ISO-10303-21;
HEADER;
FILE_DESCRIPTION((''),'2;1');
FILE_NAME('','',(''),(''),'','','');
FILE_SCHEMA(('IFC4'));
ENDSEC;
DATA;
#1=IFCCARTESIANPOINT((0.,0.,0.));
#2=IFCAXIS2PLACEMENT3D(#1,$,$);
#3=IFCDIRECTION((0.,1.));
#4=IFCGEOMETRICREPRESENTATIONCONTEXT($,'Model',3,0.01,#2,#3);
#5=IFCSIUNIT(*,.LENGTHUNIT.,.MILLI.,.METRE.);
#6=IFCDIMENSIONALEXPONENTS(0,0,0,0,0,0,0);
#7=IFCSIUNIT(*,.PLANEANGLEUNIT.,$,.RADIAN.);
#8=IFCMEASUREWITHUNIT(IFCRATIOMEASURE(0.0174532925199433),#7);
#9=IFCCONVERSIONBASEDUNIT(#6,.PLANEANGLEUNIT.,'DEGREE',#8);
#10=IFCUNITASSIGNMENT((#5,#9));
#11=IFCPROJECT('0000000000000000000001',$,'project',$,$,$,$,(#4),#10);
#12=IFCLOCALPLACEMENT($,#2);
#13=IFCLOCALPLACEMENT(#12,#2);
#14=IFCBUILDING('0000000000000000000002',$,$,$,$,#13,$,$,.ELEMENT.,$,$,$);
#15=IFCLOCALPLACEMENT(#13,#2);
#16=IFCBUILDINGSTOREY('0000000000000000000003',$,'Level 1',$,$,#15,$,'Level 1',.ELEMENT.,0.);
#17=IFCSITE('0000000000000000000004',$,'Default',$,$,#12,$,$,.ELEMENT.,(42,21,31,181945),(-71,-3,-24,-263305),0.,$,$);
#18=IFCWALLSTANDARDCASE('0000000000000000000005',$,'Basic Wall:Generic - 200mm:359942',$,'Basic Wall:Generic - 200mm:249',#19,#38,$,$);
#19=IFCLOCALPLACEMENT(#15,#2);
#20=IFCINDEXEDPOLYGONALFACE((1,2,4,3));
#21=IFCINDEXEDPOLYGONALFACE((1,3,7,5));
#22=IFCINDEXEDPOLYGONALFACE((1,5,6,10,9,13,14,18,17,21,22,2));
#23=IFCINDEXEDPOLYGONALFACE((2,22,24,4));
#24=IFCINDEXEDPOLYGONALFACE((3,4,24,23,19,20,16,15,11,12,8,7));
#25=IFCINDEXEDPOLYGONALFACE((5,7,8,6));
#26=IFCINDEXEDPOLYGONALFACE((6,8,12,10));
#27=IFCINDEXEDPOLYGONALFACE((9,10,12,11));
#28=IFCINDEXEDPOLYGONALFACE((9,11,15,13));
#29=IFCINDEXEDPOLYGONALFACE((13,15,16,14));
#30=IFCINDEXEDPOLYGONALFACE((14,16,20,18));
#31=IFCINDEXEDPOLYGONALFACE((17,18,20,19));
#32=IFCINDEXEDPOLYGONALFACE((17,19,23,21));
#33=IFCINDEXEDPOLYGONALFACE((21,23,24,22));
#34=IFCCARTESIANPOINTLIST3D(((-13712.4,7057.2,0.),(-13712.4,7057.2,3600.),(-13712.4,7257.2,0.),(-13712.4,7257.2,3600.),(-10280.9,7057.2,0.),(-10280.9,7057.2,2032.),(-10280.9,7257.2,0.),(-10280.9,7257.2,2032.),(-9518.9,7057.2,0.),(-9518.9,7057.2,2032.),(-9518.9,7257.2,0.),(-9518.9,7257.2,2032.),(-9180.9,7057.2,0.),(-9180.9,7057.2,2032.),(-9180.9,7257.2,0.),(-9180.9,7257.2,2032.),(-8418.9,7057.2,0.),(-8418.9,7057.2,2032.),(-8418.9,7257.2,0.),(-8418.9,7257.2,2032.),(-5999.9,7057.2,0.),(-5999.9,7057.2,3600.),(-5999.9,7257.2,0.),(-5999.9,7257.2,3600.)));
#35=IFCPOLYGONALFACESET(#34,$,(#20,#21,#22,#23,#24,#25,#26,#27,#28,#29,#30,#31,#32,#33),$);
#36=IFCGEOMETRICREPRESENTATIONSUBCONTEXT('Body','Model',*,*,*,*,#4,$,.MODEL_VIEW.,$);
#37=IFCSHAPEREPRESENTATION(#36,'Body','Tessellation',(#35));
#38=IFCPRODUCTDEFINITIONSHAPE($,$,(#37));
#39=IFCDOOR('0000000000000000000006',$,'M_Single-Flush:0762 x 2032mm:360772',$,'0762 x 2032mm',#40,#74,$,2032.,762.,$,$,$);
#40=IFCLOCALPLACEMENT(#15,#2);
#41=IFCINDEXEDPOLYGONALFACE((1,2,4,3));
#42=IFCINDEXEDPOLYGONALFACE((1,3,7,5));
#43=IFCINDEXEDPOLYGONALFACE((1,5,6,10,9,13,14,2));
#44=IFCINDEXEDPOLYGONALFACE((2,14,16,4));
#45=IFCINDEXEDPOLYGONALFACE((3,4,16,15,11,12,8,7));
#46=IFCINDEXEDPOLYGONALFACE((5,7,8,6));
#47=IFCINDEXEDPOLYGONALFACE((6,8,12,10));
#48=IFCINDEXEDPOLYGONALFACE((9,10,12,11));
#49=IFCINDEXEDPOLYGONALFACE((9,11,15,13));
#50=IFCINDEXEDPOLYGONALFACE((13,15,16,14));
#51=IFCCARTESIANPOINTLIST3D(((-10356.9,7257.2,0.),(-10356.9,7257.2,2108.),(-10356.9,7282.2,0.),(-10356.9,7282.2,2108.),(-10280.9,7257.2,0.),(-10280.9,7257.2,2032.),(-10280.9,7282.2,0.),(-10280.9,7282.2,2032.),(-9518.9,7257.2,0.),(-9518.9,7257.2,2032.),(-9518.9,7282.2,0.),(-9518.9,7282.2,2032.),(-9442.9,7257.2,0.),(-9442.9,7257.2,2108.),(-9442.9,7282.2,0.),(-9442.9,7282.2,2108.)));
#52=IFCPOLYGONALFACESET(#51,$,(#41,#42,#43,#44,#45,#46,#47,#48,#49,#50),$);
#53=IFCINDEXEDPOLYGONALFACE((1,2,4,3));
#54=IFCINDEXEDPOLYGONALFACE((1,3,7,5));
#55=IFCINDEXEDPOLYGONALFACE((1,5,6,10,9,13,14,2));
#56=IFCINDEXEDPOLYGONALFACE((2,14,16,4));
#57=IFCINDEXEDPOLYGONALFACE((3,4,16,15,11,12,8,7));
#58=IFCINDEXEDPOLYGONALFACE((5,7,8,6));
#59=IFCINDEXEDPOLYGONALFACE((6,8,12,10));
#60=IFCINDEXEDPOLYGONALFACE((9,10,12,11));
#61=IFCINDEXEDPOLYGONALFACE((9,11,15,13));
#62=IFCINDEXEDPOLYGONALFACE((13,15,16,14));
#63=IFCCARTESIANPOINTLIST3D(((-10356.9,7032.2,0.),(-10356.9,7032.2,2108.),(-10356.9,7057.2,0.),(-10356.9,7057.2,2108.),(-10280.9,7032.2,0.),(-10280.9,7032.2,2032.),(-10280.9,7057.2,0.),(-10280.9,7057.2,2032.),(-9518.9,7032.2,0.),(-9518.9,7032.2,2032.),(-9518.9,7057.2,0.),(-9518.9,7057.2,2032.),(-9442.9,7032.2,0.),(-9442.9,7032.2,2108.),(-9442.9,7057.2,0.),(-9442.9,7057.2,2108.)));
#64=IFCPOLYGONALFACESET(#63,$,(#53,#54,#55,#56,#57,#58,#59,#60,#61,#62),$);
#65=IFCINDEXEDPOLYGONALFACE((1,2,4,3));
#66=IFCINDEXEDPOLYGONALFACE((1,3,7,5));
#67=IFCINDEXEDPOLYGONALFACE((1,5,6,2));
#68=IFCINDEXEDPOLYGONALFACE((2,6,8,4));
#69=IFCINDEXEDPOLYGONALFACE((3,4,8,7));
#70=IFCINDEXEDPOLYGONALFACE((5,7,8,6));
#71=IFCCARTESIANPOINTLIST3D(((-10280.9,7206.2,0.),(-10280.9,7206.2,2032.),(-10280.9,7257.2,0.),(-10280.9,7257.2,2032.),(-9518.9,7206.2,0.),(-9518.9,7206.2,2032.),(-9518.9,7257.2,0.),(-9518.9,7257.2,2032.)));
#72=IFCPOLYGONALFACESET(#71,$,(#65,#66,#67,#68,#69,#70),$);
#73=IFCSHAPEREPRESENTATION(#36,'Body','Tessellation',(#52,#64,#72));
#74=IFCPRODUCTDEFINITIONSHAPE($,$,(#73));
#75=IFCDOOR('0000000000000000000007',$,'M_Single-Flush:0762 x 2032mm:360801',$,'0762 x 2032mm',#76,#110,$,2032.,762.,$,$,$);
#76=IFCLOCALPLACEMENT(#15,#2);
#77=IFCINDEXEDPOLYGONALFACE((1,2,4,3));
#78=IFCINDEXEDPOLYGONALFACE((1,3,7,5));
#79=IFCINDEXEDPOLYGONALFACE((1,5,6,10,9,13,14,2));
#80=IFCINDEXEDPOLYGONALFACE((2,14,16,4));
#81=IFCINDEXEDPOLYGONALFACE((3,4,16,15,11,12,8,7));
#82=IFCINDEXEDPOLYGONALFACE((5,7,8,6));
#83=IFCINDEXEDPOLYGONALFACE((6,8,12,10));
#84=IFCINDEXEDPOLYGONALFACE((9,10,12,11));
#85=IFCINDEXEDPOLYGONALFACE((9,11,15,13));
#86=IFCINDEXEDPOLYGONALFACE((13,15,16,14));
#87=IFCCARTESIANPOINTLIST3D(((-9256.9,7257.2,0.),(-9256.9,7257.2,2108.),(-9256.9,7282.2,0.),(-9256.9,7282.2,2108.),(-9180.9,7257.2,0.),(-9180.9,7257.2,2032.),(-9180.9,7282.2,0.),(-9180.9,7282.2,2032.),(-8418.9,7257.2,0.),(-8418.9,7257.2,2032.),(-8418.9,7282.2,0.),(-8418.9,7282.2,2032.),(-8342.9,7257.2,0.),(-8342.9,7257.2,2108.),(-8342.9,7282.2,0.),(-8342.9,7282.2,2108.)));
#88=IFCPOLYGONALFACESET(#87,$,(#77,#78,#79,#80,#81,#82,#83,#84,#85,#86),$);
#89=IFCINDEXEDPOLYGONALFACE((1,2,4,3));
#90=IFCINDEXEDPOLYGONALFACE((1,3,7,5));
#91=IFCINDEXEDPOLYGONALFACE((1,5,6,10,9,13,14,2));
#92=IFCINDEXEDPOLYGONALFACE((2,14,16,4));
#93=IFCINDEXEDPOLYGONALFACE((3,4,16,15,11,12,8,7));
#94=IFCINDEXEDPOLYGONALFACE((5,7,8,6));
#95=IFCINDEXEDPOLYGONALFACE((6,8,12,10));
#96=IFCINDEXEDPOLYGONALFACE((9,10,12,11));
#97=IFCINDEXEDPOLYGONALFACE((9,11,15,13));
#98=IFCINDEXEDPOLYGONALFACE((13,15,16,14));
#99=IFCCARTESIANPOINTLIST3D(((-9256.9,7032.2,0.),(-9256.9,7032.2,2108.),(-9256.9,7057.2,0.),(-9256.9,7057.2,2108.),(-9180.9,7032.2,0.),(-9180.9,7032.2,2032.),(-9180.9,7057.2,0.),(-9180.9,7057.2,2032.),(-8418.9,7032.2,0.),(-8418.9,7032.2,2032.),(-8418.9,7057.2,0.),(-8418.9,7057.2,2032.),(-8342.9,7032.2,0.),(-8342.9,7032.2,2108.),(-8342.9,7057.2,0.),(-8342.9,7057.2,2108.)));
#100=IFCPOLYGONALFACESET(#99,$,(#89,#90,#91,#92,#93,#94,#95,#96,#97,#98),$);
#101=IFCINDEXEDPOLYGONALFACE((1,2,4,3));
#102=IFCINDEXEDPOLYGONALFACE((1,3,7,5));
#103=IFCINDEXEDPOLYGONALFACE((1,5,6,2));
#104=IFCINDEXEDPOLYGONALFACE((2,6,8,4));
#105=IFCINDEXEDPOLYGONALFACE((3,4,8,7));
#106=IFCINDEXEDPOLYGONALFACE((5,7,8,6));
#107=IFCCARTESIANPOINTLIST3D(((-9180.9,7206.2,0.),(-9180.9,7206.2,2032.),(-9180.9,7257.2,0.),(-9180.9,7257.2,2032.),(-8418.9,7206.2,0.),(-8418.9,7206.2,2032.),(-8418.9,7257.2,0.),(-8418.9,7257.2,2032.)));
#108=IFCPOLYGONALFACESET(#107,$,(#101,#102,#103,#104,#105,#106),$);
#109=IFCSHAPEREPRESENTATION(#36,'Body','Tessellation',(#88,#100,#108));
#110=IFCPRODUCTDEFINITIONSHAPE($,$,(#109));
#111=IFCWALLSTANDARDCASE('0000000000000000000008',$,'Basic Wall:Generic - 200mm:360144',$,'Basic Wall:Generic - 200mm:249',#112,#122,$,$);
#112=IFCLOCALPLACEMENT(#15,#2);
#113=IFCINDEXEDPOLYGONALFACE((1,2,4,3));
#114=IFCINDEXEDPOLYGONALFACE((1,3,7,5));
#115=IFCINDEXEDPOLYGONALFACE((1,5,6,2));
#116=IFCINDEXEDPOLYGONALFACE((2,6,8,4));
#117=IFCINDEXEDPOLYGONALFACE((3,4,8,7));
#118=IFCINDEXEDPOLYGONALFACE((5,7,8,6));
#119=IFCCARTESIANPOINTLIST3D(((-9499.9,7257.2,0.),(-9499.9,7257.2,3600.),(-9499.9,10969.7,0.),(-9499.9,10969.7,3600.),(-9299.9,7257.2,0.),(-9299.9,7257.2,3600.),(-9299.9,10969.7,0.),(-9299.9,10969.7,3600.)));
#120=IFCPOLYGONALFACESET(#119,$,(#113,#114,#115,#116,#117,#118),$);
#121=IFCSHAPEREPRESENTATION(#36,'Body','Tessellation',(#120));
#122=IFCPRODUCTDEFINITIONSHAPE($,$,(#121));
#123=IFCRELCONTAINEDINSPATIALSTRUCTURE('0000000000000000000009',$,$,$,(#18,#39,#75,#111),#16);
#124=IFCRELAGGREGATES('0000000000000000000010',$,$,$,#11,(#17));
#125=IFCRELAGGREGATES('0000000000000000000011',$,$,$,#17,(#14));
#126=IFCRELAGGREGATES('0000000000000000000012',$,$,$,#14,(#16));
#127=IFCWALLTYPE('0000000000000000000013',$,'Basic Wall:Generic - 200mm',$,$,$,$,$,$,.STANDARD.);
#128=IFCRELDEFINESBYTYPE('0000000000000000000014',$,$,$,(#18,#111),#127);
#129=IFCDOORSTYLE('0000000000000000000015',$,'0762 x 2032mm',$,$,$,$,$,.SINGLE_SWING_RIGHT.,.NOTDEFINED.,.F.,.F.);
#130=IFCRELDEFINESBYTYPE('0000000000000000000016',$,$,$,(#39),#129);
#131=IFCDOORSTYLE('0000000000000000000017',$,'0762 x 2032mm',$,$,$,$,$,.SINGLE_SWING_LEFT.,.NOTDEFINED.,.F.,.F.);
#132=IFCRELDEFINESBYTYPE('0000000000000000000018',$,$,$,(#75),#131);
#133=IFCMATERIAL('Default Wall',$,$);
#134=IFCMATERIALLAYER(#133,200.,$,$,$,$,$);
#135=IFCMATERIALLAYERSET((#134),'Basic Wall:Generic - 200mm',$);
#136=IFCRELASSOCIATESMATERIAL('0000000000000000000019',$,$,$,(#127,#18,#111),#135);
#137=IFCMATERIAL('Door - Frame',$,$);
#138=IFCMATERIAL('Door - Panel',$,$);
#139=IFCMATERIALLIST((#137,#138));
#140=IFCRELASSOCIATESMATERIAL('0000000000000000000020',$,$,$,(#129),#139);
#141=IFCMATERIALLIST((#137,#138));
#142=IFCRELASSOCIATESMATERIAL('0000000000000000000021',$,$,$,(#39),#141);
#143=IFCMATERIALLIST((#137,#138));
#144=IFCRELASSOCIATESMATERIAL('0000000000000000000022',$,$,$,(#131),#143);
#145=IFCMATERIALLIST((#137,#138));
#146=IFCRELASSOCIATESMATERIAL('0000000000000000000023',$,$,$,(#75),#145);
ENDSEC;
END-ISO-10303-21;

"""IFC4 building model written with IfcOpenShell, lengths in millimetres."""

from ifc_helpers import new_model, entity, si_unit, converted_unit, direction, frame, frame_2d, origin, place, context, subcontext, project, spatial, polyline, rectangle, outline, extrude, clip, bounded_halfspace, source, transform, mapped, material, material_list, layer, layer_set, layer_usage, type_object, type_shapes, element, fill, save


model = new_model("IFC4")

# Units and contexts
model_context = context("Model", 3, precision=0.01, world=origin(), true_north=direction((0.0, 1.0)))
body_context = subcontext(model_context, "Body", "Model", "MODEL_VIEW")
ifc_project = project(units=[si_unit("LENGTHUNIT", "METRE", prefix="MILLI"), converted_unit("PLANEANGLEUNIT", "DEGREE", entity("IfcRatioMeasure", 0.0174532925199433), si_unit("PLANEANGLEUNIT", "RADIAN"), dimensions=[0, 0, 0, 0, 0, 0, 0])], contexts=[model_context])

# Site, building, storey
site_placement = place(None, origin())
site = spatial("IfcSite", under=ifc_project, at=site_placement, Name="Default", CompositionType="ELEMENT", RefLatitude=(42, 21, 31, 181945), RefLongitude=(-71, -3, -24, -263305), RefElevation=0.0)
building_placement = place(site_placement, origin())
building = spatial("IfcBuilding", under=site, at=building_placement, CompositionType="ELEMENT")
storey_placement = place(building_placement, origin())
storey = spatial("IfcBuildingStorey", under=building, at=storey_placement, Name="Level 1", LongName="Level 1", CompositionType="ELEMENT", Elevation=0.0)

# Shared definitions
ifc_material_1 = material(Name="Default Wall")

# Wall, openings, doors
ifc_layer_1 = layer(ifc_material_1, 200.0)
ifc_layer_set_1 = layer_set([ifc_layer_1], Name="Basic Wall:Generic - 200mm")
ifc_layer_usage_1 = layer_usage(ifc_layer_set_1, "AXIS2", "NEGATIVE", 100.0)
wall_type_1 = type_object("IfcWallType", Name="Basic Wall:Generic - 200mm", PredefinedType="STANDARD", material=ifc_layer_set_1)
wall_1_placement = place(storey_placement, frame((-13712.4, 7157.2, 0.0)))
wall_1 = element("IfcWallStandardCase", 1, at=wall_1_placement, inside=storey, type_object=wall_type_1, material=ifc_layer_usage_1, Name="Basic Wall:Generic - 200mm:359942", ObjectType="Basic Wall:Generic - 200mm:249", context=body_context, shape_type="Clipping", body=[
    clip(extrude(rectangle(XDim=7712.5, YDim=200.0, at=frame_2d((3856.2, 0.0), x_axis=(-1.0, 0.0))), origin(), (0.0, 0.0, 1.0), 3600.0), bounded_halfspace(frame((0.0, -100.0, 3600.0), z_axis=(0.0, 0.0, -1.0), x_axis=(1.0, 0.0, 0.0)), True, frame((0.0, -100.0, 3600.0)), polyline([(0.0, 0.0), (3212.5, 0.0), (3412.5, 0.0), (7712.5, 0.0), (7712.5, 200.0), (4412.5, 200.0), (4212.5, 200.0), (0.0, 200.0), (0.0, 0.0)]))),
])
opening_1_placement = place(wall_1_placement, frame((3431.5, -100.0, 0.0)))
opening_1 = element("IfcOpeningElement", 2, at=opening_1_placement, cuts=wall_1, ObjectType="Opening", context=body_context, shape_type="SweptSolid", body=[
    extrude(rectangle(XDim=762.0, YDim=2032.0, at=frame_2d((1016.0, 381.0), x_axis=(0.0, 1.0))), frame((0.0, 0.0, 0.0), z_axis=(0.0, 1.0, 0.0), x_axis=(0.0, 0.0, 1.0)), (0.0, 0.0, 1.0), 200.0),
])
opening_2_placement = place(wall_1_placement, frame((4531.5, -100.0, 0.0)))
opening_2 = element("IfcOpeningElement", 3, at=opening_2_placement, cuts=wall_1, ObjectType="Opening", context=body_context, shape_type="SweptSolid", body=[
    extrude(rectangle(XDim=762.0, YDim=2032.0, at=frame_2d((1016.0, 381.0), x_axis=(0.0, -1.0))), frame((0.0, 0.0, 0.0), z_axis=(0.0, 1.0, 0.0), x_axis=(0.0, 0.0, 1.0)), (0.0, 0.0, 1.0), 200.0),
])
ifc_material_2 = material(Name="Door - Frame")
ifc_material_3 = material(Name="Door - Panel")
ifc_material_list_1 = material_list([ifc_material_2, ifc_material_3])
ifc_material_list_2 = material_list([ifc_material_2, ifc_material_3])
door_style_1 = type_object("IfcDoorStyle", Name="0762 x 2032mm", ConstructionType="NOTDEFINED", OperationType="SINGLE_SWING_RIGHT", ParameterTakesPrecedence=False, Sizeable=False, material=ifc_material_list_2)
shared_shape_1 = source(origin(), body_context, "Body", "SweptSolid", [
    extrude(outline(polyline([(-457.0, -1073.0), (457.0, -1073.0), (457.0, 1035.0), (381.0, 1035.0), (381.0, -997.0), (-381.0, -997.0), (-381.0, 1035.0), (-457.0, 1035.0), (-457.0, -1073.0)])), frame((381.0, 200.0, 1035.0), z_axis=(0.0, 1.0, 0.0), x_axis=(1.0, 0.0, 0.0)), (0.0, 0.0, 1.0), 25.0),
    extrude(outline(polyline([(-1073.0, -457.0), (1035.0, -457.0), (1035.0, -381.0), (-997.0, -381.0), (-997.0, 381.0), (1035.0, 381.0), (1035.0, 457.0), (-1073.0, 457.0), (-1073.0, -457.0)])), frame((381.0, -25.0, 1035.0), z_axis=(0.0, 1.0, 0.0), x_axis=(0.0, 0.0, -1.0)), (0.0, 0.0, 1.0), 25.0),
    extrude(rectangle(XDim=51.0, YDim=762.0, at=frame_2d((0.0, 0.0), x_axis=(1.0, 0.0))), frame((381.0, 174.5, 0.0), z_axis=(0.0, 0.0, 1.0), x_axis=(0.0, 1.0, 0.0)), (0.0, 0.0, 1.0), 2032.0),
])
type_shapes(door_style_1, [shared_shape_1])
door_1_placement = place(opening_1_placement, origin())
door_1 = element("IfcDoor", 4, at=door_1_placement, inside=storey, type_object=door_style_1, material=ifc_material_list_1, Name="M_Single-Flush:0762 x 2032mm:360772", ObjectType="0762 x 2032mm", OverallHeight=2032.0, OverallWidth=762.0, context=body_context, shape_type="MappedRepresentation", body=[
    mapped(shared_shape_1, transform((0.0, 0.0, 0.0), scale=1.0)),
])
fill(opening_1, door_1)
ifc_material_list_3 = material_list([ifc_material_2, ifc_material_3])
ifc_material_list_4 = material_list([ifc_material_2, ifc_material_3])
door_style_2 = type_object("IfcDoorStyle", Name="0762 x 2032mm", ConstructionType="NOTDEFINED", OperationType="SINGLE_SWING_LEFT", ParameterTakesPrecedence=False, Sizeable=False, material=ifc_material_list_4)
shared_shape_2 = source(origin(), body_context, "Body", "SweptSolid", [
    extrude(outline(polyline([(-457.0, -1073.0), (457.0, -1073.0), (457.0, 1035.0), (381.0, 1035.0), (381.0, -997.0), (-381.0, -997.0), (-381.0, 1035.0), (-457.0, 1035.0), (-457.0, -1073.0)])), frame((381.0, 225.0, 1035.0), z_axis=(0.0, -1.0, 0.0), x_axis=(-1.0, 0.0, 0.0)), (0.0, 0.0, 1.0), 25.0),
    extrude(outline(polyline([(-1073.0, -457.0), (1035.0, -457.0), (1035.0, -381.0), (-997.0, -381.0), (-997.0, 381.0), (1035.0, 381.0), (1035.0, 457.0), (-1073.0, 457.0), (-1073.0, -457.0)])), frame((381.0, 0.0, 1035.0), z_axis=(0.0, -1.0, 0.0), x_axis=(0.0, 0.0, -1.0)), (0.0, 0.0, 1.0), 25.0),
    extrude(rectangle(XDim=762.0, YDim=51.0, at=frame_2d((0.0, 0.0), x_axis=(1.0, 0.0))), frame((381.0, 174.5, 0.0)), (0.0, 0.0, 1.0), 2032.0),
])
type_shapes(door_style_2, [shared_shape_2])
door_2_placement = place(opening_2_placement, origin())
door_2 = element("IfcDoor", 5, at=door_2_placement, inside=storey, type_object=door_style_2, material=ifc_material_list_3, Name="M_Single-Flush:0762 x 2032mm:360801", ObjectType="0762 x 2032mm", OverallHeight=2032.0, OverallWidth=762.0, context=body_context, shape_type="MappedRepresentation", body=[
    mapped(shared_shape_2, transform((0.0, 0.0, 0.0), scale=1.0)),
])
fill(opening_2, door_2)

# Wall
ifc_layer_usage_2 = layer_usage(ifc_layer_set_1, "AXIS2", "NEGATIVE", 100.0)
wall_2_placement = place(storey_placement, frame((-9399.9, 7257.2, 0.0), z_axis=(0.0, 0.0, 1.0), x_axis=(0.0, 1.0, 0.0)))
element("IfcWallStandardCase", 6, at=wall_2_placement, inside=storey, type_object=wall_type_1, material=ifc_layer_usage_2, Name="Basic Wall:Generic - 200mm:360144", ObjectType="Basic Wall:Generic - 200mm:249", context=body_context, shape_type="Clipping", body=[
    clip(extrude(rectangle(XDim=3712.5, YDim=200.0, at=frame_2d((1856.3, 0.0), x_axis=(-1.0, 0.0))), origin(), (0.0, 0.0, 1.0), 3600.0), bounded_halfspace(frame((0.0, -100.0, 3600.0), z_axis=(0.0, 0.0, -1.0), x_axis=(0.0, -1.0, 0.0)), True, frame((0.0, -100.0, 3600.0)), polyline([(0.0, 0.0), (3712.5, 0.0), (3712.5, 200.0), (0.0, 200.0), (0.0, 0.0)]))),
])

save(model, "model.ifc")
